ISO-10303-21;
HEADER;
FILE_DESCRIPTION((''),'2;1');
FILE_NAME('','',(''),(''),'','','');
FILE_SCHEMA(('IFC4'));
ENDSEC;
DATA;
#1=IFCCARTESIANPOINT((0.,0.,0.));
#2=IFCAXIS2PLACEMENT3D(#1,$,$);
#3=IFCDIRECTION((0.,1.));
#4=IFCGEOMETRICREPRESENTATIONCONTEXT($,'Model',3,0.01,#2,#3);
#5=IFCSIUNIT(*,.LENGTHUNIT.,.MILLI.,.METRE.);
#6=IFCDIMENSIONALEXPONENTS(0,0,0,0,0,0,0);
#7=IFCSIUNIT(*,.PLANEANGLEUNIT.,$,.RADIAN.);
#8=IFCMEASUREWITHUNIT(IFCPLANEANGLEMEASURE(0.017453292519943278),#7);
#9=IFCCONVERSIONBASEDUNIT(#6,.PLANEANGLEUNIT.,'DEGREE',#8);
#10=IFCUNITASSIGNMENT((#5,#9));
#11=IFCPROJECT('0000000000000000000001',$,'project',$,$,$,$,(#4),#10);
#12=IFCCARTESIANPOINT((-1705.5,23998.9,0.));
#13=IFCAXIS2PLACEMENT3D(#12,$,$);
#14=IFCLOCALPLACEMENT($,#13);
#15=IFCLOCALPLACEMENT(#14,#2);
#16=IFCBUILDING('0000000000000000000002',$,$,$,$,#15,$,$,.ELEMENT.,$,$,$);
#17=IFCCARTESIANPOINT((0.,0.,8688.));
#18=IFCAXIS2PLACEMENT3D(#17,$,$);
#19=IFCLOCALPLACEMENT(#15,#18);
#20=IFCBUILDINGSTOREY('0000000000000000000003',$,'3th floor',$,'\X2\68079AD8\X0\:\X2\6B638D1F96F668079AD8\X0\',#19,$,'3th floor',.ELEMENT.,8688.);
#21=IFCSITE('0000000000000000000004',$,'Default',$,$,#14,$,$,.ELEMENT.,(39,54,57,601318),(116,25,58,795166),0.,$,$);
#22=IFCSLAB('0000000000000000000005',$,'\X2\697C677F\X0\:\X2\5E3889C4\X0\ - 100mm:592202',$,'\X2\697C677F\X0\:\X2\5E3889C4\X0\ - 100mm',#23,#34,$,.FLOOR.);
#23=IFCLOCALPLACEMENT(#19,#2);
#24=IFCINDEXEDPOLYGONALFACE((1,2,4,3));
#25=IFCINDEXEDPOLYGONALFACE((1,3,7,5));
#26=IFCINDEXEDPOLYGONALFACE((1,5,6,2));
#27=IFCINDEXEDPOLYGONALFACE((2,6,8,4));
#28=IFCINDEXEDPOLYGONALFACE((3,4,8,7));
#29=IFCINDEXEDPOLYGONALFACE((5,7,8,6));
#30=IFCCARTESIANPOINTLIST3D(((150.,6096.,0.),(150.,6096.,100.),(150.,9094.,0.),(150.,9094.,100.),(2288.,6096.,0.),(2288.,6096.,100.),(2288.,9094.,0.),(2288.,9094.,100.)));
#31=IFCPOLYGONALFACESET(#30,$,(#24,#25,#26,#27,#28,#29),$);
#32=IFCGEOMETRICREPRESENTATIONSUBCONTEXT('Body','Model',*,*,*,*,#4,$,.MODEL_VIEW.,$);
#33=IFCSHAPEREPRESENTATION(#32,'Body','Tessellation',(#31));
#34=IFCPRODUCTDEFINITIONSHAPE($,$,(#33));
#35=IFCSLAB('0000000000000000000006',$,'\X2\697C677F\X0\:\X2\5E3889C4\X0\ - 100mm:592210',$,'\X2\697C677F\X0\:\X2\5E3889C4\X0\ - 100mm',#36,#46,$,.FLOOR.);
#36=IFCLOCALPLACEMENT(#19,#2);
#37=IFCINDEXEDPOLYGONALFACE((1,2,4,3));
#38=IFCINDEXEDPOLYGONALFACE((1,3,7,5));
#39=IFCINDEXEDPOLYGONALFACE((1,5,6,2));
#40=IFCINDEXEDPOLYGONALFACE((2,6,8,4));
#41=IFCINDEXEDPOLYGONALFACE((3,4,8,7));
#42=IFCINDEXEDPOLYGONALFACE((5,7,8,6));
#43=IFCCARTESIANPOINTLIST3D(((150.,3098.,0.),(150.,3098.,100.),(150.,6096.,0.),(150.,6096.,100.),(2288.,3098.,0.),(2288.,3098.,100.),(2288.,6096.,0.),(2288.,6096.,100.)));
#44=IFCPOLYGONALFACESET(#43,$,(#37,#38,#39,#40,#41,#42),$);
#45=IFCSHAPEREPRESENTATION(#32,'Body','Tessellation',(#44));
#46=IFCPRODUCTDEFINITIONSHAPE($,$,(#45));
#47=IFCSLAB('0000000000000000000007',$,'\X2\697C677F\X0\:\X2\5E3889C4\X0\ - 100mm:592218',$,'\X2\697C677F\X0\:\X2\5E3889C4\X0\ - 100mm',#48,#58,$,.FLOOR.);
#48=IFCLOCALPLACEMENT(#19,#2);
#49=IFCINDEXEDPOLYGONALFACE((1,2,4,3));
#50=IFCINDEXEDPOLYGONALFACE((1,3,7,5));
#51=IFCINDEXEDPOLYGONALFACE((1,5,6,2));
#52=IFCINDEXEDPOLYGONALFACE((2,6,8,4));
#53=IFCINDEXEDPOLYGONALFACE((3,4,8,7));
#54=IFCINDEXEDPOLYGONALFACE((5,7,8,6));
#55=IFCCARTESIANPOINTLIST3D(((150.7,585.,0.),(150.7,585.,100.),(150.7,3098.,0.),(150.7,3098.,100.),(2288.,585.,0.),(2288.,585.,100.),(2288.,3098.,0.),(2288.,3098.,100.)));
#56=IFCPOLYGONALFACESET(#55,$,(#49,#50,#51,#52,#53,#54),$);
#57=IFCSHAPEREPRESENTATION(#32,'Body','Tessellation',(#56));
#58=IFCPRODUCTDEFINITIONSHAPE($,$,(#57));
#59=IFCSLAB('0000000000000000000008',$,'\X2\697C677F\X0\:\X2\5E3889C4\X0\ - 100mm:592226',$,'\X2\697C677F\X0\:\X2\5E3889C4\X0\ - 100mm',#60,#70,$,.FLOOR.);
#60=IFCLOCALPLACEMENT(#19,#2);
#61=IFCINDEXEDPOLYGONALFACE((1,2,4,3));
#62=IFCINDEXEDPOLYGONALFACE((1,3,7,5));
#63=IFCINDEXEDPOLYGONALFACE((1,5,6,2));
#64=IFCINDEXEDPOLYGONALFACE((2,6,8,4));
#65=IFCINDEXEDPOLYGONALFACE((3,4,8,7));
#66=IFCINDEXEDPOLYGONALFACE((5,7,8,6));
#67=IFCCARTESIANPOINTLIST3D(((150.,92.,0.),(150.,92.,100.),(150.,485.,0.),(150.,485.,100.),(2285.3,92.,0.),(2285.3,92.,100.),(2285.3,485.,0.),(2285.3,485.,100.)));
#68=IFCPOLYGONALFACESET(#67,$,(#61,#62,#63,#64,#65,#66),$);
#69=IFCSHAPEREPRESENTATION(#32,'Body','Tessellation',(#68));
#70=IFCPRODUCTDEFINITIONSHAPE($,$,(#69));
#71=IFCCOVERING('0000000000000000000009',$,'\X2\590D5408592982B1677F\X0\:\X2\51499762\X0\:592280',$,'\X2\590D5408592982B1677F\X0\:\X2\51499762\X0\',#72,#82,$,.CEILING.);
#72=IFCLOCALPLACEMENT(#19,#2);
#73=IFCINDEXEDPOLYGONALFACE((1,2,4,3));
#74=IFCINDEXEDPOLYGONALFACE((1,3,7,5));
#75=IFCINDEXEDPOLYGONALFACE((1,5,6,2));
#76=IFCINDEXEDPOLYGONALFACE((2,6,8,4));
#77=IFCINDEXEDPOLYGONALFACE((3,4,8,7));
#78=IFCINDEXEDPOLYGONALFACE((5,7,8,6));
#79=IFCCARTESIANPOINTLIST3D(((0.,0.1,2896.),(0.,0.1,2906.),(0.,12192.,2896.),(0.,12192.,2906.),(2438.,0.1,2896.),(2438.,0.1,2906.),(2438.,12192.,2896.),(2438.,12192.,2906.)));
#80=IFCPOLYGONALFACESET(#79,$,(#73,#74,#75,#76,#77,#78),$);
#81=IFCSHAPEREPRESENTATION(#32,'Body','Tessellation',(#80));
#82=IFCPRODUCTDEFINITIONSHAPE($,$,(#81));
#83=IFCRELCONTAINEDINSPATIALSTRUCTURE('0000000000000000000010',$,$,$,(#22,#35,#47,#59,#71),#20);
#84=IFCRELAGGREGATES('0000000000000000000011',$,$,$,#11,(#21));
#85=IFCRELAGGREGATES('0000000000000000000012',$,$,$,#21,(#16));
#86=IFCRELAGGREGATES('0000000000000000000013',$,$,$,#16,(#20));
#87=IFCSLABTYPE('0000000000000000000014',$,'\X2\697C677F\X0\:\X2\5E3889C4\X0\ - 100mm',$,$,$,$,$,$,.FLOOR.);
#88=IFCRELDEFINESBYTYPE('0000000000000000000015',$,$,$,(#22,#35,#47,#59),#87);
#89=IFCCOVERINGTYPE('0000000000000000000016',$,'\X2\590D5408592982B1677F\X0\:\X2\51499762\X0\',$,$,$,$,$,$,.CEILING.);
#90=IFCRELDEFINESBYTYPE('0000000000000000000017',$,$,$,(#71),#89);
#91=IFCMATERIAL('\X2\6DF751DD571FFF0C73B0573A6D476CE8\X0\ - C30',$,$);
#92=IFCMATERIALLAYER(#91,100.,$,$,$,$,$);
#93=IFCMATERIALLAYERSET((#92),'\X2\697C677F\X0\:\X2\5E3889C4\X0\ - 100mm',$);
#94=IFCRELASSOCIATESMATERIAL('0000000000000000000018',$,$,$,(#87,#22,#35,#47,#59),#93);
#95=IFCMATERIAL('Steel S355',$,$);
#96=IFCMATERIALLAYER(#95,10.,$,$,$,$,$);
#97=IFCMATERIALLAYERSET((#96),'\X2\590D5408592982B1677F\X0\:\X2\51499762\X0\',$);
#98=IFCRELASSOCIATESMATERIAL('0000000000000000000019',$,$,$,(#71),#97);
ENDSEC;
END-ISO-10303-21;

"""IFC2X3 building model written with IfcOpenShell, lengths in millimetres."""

from ifc_helpers import new_model, entity, si_unit, converted_unit, direction, frame, frame_2d, origin, origin_2d_with_axis, place, context, subcontext, project, spatial, rectangle, extrude, material, layer, layer_set, layer_usage, type_object, element, save


model = new_model("IFC2X3")

# Units and contexts
model_context = context("Model", 3, precision=0.01, world=origin(), true_north=direction((0.0, 1.0)))
body_context = subcontext(model_context, "Body", "Model", "MODEL_VIEW")
ifc_project = project(units=[si_unit("LENGTHUNIT", "METRE", prefix="MILLI"), converted_unit("PLANEANGLEUNIT", "DEGREE", entity("IfcPlaneAngleMeasure", 0.017453292519943278), si_unit("PLANEANGLEUNIT", "RADIAN"), dimensions=[0, 0, 0, 0, 0, 0, 0])], contexts=[model_context])

# Site, building, storey
site_placement = place(None, frame((-1705.5, 23998.9, 0.0)))
site = spatial("IfcSite", under=ifc_project, at=site_placement, Name="Default", CompositionType="ELEMENT", RefLatitude=(39, 54, 57, 601318), RefLongitude=(116, 25, 58, 795166), RefElevation=0.0)
building_placement = place(site_placement, origin())
building = spatial("IfcBuilding", under=site, at=building_placement, CompositionType="ELEMENT")
storey_placement = place(building_placement, frame((0.0, 0.0, 8688.0)))
storey = spatial("IfcBuildingStorey", under=building, at=storey_placement, Name="3th floor", ObjectType="标高:正负零标高", LongName="3th floor", CompositionType="ELEMENT", Elevation=8688.0)

# Shared definitions
ifc_material_1 = material(Name="Steel S355")

# Slabs
ifc_material_2 = material(Name="混凝土，现场浇注 - C30")
ifc_layer_1 = layer(ifc_material_2, 100.0)
ifc_layer_set_1 = layer_set([ifc_layer_1], Name="楼板:常规 - 100mm")
slab_type = type_object("IfcSlabType", Name="楼板:常规 - 100mm", PredefinedType="FLOOR", material=ifc_layer_set_1)
ifc_layer_usage_1 = layer_usage(ifc_layer_set_1, "AXIS3", "POSITIVE", 0.0)
slab_1_placement = place(storey_placement, origin())
element("IfcSlab", 1, at=slab_1_placement, inside=storey, type_object=slab_type, material=ifc_layer_usage_1, Name="楼板:常规 - 100mm:592202", ObjectType="楼板:常规 - 100mm", PredefinedType="FLOOR", context=body_context, shape_type="SweptSolid", body=[
    extrude(rectangle(XDim=2998.0, YDim=2138.0, at=origin_2d_with_axis()), frame((1219.0, 7595.0, 100.0), z_axis=(0.0, 0.0, -1.0), x_axis=(0.0, 1.0, 0.0)), (0.0, 0.0, 1.0), 100.0),
])
ifc_layer_usage_2 = layer_usage(ifc_layer_set_1, "AXIS3", "POSITIVE", 0.0)
slab_2_placement = place(storey_placement, origin())
element("IfcSlab", 2, at=slab_2_placement, inside=storey, type_object=slab_type, material=ifc_layer_usage_2, Name="楼板:常规 - 100mm:592210", ObjectType="楼板:常规 - 100mm", PredefinedType="FLOOR", context=body_context, shape_type="SweptSolid", body=[
    extrude(rectangle(XDim=2998.0, YDim=2138.0, at=origin_2d_with_axis()), frame((1219.0, 4597.0, 100.0), z_axis=(0.0, 0.0, -1.0), x_axis=(0.0, 1.0, 0.0)), (0.0, 0.0, 1.0), 100.0),
])
ifc_layer_usage_3 = layer_usage(ifc_layer_set_1, "AXIS3", "POSITIVE", 0.0)
slab_3_placement = place(storey_placement, origin())
element("IfcSlab", 3, at=slab_3_placement, inside=storey, type_object=slab_type, material=ifc_layer_usage_3, Name="楼板:常规 - 100mm:592218", ObjectType="楼板:常规 - 100mm", PredefinedType="FLOOR", context=body_context, shape_type="SweptSolid", body=[
    extrude(rectangle(XDim=2513.0, YDim=2137.3, at=frame_2d((0.0, 0.0), x_axis=(1.0, 0.0))), frame((1219.3, 1841.5, 100.0), z_axis=(0.0, 0.0, -1.0), x_axis=(0.0, 1.0, 0.0)), (0.0, 0.0, 1.0), 100.0),
])
ifc_layer_usage_4 = layer_usage(ifc_layer_set_1, "AXIS3", "POSITIVE", 0.0)
slab_4_placement = place(storey_placement, origin())
element("IfcSlab", 4, at=slab_4_placement, inside=storey, type_object=slab_type, material=ifc_layer_usage_4, Name="楼板:常规 - 100mm:592226", ObjectType="楼板:常规 - 100mm", PredefinedType="FLOOR", context=body_context, shape_type="SweptSolid", body=[
    extrude(rectangle(XDim=393.0, YDim=2135.3, at=frame_2d((0.0, 0.0), x_axis=(1.0, 0.0))), frame((1217.7, 288.5, 100.0), z_axis=(0.0, 0.0, -1.0), x_axis=(0.0, 1.0, 0.0)), (0.0, 0.0, 1.0), 100.0),
])

# Covering
ifc_layer_2 = layer(ifc_material_1, 10.0)
ifc_layer_set_2 = layer_set([ifc_layer_2], Name="复合天花板:光面")
ifc_layer_usage_5 = layer_usage(ifc_layer_set_2, "AXIS3", "NEGATIVE", 10.0)
covering_type = type_object("IfcCoveringType", Name="复合天花板:光面", PredefinedType="CEILING")
covering_placement = place(storey_placement, origin())
element("IfcCovering", 5, at=covering_placement, inside=storey, type_object=covering_type, material=ifc_layer_usage_5, Name="复合天花板:光面:592280", ObjectType="复合天花板:光面", PredefinedType="CEILING", context=body_context, shape_type="SweptSolid", body=[
    extrude(rectangle(XDim=12191.9, YDim=2438.0, at=origin_2d_with_axis()), frame((1219.0, 6096.0, 2896.0), z_axis=(0.0, 0.0, 1.0), x_axis=(0.0, 1.0, 0.0)), (0.0, 0.0, 1.0), 10.0),
])

save(model, "model.ifc")
